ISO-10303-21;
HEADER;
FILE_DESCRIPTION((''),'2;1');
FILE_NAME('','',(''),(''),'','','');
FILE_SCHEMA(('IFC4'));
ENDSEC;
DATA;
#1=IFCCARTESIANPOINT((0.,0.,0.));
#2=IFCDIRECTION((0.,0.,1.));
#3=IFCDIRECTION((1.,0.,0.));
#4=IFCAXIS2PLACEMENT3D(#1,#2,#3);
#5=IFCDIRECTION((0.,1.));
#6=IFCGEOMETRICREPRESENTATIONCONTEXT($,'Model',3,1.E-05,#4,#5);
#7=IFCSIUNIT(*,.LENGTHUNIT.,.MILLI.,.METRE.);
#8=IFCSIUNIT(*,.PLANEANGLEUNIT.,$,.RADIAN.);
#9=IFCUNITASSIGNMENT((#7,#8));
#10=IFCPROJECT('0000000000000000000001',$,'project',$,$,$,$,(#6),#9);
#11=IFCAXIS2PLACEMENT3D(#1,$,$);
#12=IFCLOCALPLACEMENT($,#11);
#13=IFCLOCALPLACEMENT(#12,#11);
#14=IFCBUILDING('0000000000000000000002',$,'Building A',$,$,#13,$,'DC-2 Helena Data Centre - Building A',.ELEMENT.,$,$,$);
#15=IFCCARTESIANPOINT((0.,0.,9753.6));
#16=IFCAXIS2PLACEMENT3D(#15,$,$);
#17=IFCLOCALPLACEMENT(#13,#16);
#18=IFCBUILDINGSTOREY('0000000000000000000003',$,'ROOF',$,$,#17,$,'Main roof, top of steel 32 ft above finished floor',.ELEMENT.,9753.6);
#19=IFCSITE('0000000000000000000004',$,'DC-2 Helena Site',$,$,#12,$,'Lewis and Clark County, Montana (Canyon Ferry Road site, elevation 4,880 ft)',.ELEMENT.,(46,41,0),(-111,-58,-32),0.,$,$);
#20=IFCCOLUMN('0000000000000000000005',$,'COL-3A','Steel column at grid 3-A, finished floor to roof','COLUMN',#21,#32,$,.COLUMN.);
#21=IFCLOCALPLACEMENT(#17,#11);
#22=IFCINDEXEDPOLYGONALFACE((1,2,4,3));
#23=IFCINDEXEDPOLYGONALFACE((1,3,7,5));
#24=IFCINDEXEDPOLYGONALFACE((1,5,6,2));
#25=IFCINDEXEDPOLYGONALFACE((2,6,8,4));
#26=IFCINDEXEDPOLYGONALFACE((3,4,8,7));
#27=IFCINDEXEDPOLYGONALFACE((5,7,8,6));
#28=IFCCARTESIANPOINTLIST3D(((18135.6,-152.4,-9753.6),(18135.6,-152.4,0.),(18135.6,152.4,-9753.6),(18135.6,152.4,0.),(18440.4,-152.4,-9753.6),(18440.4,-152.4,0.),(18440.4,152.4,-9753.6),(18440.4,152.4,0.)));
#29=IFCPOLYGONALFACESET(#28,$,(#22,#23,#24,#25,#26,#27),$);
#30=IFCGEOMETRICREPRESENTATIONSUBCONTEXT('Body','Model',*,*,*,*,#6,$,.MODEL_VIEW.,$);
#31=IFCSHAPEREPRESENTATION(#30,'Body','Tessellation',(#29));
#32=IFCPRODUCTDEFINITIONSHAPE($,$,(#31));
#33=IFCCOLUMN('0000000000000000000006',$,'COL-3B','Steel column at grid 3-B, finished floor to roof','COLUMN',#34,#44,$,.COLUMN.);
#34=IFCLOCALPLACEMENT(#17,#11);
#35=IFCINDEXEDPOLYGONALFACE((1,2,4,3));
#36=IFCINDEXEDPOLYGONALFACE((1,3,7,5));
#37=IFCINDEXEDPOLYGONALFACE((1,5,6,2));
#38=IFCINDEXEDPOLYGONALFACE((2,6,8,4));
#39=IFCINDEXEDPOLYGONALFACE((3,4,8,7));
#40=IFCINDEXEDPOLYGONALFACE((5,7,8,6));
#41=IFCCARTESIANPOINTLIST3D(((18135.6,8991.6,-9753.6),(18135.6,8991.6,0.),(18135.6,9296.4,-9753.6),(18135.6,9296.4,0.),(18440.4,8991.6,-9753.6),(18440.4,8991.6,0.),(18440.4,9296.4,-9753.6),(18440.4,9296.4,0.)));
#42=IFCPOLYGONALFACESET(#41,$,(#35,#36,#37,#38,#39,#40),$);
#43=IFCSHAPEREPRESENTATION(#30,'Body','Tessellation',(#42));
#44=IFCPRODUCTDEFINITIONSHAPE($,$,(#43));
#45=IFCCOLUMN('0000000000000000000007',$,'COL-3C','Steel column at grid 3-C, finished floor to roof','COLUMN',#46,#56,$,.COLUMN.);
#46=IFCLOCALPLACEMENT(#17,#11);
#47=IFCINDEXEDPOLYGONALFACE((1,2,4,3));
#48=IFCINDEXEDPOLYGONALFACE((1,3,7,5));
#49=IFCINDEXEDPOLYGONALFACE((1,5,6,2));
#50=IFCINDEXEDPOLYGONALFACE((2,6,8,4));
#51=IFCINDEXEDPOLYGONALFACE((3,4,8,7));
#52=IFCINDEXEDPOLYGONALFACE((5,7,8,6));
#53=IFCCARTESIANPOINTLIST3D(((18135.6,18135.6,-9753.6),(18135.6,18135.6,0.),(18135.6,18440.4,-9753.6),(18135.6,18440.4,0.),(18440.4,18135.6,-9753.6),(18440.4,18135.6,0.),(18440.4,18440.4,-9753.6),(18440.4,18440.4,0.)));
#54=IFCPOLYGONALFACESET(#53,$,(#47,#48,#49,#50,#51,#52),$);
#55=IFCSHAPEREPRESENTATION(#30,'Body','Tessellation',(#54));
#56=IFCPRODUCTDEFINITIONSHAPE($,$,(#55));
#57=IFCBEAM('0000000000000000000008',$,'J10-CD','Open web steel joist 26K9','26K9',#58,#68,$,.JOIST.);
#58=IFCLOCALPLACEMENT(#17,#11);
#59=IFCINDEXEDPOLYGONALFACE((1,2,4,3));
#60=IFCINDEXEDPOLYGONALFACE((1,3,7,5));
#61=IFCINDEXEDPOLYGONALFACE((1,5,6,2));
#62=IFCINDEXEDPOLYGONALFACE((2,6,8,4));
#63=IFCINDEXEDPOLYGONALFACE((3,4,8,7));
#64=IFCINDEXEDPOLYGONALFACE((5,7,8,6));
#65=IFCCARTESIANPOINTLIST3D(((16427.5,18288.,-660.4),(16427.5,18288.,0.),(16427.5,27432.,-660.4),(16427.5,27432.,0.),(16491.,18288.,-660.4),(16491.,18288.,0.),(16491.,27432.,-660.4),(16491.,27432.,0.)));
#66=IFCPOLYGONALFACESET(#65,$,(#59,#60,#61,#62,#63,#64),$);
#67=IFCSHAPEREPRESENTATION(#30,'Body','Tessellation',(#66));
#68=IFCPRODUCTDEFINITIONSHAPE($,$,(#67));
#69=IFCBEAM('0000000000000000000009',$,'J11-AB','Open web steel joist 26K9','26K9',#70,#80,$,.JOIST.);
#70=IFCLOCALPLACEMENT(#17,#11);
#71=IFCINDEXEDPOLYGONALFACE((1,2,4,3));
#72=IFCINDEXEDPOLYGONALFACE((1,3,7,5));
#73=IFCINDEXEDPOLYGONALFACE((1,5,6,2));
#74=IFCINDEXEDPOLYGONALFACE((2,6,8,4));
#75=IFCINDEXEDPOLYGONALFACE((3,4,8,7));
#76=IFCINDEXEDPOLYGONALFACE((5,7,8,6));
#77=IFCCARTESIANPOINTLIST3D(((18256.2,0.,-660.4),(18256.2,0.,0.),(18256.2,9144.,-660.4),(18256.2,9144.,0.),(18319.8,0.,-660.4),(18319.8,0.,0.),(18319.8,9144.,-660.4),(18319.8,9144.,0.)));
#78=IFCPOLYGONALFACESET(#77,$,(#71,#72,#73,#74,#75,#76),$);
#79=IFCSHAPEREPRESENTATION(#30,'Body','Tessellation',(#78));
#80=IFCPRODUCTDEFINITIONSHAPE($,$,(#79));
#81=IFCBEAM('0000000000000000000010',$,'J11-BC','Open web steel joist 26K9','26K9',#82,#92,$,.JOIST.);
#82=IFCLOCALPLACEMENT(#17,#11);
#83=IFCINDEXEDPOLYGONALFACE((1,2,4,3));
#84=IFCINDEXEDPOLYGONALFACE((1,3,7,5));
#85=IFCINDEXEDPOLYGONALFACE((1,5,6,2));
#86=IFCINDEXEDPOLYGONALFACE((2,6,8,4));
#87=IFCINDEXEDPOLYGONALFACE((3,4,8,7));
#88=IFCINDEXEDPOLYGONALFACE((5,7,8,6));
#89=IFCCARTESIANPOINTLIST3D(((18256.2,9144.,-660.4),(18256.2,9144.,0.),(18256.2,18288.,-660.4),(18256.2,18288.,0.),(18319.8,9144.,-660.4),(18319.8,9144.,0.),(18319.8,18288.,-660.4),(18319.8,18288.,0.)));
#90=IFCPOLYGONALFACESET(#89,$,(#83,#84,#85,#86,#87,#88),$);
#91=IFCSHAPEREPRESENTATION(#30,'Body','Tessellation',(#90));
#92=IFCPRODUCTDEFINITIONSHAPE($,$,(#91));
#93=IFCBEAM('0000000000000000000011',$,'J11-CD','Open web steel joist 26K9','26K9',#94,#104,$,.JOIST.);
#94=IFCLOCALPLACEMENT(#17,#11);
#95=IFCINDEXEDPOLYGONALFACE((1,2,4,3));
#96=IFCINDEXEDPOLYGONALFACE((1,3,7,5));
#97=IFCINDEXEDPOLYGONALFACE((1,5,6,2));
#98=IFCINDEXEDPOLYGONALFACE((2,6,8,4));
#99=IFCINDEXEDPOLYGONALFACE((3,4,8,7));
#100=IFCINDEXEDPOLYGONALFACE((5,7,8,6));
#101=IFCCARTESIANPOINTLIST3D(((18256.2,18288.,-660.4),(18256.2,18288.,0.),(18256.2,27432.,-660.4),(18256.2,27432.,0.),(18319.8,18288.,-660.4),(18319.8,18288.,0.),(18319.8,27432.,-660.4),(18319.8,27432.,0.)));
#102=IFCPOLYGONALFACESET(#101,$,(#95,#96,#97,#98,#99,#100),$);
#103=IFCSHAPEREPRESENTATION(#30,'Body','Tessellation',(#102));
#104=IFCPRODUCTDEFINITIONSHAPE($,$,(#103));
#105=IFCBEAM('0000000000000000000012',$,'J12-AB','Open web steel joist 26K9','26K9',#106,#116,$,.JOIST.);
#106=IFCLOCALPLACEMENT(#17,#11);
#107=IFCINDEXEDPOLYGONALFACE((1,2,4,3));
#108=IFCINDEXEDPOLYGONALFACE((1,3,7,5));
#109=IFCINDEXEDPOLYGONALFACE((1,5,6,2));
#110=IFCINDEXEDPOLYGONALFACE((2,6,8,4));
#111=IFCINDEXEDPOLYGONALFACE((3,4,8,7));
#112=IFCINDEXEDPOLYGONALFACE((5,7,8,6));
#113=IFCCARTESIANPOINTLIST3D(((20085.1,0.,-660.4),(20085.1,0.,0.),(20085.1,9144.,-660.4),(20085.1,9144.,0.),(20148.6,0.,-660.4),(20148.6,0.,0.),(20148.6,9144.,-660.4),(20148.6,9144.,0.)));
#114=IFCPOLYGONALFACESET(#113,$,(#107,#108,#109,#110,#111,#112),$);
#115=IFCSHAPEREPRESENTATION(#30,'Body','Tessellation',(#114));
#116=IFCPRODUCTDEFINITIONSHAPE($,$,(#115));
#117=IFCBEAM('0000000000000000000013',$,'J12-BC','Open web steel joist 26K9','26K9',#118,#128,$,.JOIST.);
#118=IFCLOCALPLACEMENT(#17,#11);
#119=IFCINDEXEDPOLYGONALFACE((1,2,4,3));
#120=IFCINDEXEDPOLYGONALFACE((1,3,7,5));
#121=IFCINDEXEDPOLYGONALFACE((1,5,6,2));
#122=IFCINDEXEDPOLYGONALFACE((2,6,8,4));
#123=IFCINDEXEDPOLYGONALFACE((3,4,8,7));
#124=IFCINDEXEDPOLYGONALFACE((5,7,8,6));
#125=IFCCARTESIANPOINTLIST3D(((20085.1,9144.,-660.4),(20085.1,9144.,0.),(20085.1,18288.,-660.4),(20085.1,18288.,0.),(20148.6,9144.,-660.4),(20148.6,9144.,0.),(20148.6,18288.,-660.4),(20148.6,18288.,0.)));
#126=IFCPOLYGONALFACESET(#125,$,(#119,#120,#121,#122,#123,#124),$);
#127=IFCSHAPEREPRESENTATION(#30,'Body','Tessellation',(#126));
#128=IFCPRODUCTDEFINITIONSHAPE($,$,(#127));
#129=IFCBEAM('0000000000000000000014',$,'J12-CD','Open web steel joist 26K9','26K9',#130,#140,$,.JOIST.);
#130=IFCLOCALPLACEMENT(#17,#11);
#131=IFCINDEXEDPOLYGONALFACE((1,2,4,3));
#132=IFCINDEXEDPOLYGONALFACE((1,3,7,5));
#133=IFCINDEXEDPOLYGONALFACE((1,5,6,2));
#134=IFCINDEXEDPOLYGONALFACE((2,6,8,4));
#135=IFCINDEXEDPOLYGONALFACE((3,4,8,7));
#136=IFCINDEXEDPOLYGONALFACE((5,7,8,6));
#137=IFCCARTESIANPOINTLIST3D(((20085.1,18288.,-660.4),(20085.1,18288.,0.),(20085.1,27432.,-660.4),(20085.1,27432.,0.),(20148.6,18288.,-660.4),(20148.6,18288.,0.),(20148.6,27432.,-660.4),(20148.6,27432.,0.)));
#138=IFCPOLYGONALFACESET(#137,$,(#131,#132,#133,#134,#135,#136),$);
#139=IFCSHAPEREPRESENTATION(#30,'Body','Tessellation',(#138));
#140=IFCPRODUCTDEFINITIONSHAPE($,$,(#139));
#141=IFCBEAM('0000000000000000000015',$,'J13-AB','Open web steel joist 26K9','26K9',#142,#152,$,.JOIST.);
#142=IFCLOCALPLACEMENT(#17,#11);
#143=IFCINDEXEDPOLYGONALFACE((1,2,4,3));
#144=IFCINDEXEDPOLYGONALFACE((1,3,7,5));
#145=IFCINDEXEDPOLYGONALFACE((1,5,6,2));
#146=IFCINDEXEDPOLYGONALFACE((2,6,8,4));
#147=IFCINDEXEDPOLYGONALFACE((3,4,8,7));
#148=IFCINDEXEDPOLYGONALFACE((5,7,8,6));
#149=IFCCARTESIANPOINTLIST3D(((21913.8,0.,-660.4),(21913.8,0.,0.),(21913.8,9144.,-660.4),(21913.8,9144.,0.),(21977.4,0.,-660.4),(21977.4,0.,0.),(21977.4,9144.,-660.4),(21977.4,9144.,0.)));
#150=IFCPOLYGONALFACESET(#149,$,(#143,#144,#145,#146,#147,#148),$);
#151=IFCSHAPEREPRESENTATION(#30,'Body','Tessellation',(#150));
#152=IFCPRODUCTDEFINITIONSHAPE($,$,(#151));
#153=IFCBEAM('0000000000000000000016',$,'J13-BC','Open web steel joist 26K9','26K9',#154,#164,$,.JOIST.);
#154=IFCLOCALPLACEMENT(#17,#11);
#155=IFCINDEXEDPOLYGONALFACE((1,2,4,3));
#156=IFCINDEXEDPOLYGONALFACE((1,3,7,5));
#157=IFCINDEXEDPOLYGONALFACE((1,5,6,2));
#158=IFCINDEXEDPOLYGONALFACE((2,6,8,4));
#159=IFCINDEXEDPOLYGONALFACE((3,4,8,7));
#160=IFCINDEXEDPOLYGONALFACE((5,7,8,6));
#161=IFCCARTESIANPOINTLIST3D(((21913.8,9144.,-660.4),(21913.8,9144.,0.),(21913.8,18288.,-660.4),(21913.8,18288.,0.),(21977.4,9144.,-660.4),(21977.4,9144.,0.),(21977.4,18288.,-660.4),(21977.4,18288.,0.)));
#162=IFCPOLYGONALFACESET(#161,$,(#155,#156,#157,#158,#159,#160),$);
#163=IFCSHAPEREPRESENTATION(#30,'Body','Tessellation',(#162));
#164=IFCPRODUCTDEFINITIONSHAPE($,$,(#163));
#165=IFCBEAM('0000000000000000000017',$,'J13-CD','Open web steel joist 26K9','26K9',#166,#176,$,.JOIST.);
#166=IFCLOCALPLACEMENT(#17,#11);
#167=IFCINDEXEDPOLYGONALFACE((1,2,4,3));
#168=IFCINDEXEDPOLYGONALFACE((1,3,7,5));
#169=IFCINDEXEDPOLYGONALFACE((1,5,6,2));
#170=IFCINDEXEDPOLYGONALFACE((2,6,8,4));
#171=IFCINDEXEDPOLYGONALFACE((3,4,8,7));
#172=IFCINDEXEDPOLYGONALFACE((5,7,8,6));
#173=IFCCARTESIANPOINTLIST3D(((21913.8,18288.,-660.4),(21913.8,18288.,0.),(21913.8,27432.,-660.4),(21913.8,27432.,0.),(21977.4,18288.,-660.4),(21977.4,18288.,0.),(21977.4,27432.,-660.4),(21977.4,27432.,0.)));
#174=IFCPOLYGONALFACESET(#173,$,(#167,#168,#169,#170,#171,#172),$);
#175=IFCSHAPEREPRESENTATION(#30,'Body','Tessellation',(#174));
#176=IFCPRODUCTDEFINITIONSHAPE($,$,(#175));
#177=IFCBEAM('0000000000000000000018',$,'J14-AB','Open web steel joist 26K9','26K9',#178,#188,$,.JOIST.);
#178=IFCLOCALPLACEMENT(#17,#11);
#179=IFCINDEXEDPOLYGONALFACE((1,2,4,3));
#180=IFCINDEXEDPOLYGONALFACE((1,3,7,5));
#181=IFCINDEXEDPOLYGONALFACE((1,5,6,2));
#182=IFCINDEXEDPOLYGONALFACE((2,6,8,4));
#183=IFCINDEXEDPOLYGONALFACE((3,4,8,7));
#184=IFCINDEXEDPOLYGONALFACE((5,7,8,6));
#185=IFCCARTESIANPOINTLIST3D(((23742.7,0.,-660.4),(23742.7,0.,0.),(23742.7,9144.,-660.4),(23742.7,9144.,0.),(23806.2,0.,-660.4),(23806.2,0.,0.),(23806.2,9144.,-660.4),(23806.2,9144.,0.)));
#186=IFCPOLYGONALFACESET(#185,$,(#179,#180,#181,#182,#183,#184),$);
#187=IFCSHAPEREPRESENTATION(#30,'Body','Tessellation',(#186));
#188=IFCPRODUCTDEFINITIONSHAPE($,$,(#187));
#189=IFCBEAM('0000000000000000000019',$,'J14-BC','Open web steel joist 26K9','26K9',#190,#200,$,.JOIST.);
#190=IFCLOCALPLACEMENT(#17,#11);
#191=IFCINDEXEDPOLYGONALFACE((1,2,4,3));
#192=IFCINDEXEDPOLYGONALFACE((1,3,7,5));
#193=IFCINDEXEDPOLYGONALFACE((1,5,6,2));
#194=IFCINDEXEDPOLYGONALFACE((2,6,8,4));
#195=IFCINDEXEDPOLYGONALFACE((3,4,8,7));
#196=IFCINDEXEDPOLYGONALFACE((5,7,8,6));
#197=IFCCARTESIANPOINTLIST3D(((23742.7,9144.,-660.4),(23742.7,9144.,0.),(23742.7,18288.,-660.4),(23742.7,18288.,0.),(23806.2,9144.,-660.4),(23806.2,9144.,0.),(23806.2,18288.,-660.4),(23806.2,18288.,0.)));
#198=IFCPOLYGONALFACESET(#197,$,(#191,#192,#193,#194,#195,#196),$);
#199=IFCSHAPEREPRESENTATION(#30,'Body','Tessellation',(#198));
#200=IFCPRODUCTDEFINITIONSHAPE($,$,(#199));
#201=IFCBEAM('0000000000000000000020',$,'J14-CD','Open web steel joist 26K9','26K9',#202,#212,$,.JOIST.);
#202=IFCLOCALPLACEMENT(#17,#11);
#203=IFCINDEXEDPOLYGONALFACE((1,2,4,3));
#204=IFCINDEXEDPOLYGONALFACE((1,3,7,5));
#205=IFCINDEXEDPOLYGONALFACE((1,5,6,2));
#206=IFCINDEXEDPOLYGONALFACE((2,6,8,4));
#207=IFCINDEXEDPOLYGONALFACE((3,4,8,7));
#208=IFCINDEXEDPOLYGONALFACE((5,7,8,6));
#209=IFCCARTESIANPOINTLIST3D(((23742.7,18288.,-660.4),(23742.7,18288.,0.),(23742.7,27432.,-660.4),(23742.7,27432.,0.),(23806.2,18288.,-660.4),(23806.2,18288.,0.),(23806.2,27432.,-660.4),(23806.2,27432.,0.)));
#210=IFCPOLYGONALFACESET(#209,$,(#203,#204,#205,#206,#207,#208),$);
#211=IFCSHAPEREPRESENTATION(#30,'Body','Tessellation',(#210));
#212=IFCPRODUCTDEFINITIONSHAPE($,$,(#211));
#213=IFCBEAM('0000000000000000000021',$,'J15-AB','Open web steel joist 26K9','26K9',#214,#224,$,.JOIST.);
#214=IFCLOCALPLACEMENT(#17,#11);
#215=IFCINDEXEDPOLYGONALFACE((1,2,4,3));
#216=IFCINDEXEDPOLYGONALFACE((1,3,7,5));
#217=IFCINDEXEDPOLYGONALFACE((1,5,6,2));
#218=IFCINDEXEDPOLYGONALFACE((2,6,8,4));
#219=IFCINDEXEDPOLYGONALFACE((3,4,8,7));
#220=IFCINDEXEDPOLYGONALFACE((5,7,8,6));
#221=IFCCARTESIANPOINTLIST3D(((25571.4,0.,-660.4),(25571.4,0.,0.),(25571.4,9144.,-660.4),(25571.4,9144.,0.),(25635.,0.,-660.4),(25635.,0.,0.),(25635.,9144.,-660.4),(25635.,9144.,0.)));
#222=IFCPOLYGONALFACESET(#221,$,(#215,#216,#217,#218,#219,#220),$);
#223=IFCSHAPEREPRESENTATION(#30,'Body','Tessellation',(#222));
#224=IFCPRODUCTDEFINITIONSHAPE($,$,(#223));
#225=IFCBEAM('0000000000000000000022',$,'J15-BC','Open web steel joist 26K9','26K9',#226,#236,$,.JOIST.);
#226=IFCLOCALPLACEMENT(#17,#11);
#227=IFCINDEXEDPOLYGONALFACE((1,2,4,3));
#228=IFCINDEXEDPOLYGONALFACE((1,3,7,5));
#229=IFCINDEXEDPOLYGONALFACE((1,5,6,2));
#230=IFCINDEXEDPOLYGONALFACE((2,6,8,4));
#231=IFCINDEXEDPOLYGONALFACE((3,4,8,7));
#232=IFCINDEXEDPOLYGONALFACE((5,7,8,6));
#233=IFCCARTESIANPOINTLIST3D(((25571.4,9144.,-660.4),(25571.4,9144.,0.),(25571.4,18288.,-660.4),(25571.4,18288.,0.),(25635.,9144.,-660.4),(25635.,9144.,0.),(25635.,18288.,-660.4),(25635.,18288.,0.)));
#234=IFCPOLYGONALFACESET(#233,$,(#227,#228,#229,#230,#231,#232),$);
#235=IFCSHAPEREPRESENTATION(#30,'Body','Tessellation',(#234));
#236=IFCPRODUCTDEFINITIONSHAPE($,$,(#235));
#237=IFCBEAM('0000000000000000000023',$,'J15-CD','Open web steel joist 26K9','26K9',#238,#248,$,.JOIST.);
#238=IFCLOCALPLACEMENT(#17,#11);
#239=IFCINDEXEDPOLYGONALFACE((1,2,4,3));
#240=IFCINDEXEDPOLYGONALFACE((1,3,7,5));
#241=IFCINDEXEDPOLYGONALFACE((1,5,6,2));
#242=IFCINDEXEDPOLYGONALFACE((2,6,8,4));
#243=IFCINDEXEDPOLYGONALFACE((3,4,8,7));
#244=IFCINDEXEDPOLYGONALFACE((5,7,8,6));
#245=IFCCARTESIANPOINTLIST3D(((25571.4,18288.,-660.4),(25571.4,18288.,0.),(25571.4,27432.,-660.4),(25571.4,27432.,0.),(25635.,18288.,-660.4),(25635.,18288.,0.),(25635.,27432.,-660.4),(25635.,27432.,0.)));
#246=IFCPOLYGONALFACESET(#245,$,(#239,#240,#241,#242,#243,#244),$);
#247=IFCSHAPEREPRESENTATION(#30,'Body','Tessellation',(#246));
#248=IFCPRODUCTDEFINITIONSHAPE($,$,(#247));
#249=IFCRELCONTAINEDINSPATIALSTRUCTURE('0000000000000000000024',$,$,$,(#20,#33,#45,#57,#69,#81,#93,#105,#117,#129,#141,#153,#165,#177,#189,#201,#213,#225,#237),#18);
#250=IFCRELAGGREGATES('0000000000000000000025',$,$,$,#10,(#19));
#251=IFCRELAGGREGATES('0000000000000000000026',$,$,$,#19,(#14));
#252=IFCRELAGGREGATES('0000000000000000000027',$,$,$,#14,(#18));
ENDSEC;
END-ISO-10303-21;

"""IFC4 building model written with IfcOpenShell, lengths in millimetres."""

from ifc_helpers import new_model, si_unit, direction, frame, origin, origin_with_axes, origin_2d, place, context, subcontext, project, spatial, rectangle, extrude, element, save


model = new_model("IFC4")

# Units and contexts
model_context = context("Model", 3, precision=1e-05, world=origin_with_axes(), true_north=direction((0.0, 1.0)))
body_context = subcontext(model_context, "Body", "Model", "MODEL_VIEW")
ifc_project = project(units=[si_unit("LENGTHUNIT", "METRE", prefix="MILLI"), si_unit("PLANEANGLEUNIT", "RADIAN")], contexts=[model_context])

# Site, building, storey
site_placement = place(None, origin())
site = spatial("IfcSite", under=ifc_project, at=site_placement, Name="DC-2 Helena Site", LongName="Lewis and Clark County, Montana (Canyon Ferry Road site, elevation 4,880 ft)", CompositionType="ELEMENT", RefLatitude=(46, 41, 0), RefLongitude=(-111, -58, -32), RefElevation=0.0)
building_placement = place(site_placement, origin())
building = spatial("IfcBuilding", under=site, at=building_placement, Name="Building A", LongName="DC-2 Helena Data Centre - Building A", CompositionType="ELEMENT")
storey_placement = place(building_placement, frame((0.0, 0.0, 9753.6)))
storey = spatial("IfcBuildingStorey", under=building, at=storey_placement, Name="ROOF", LongName="Main roof, top of steel 32 ft above finished floor", CompositionType="ELEMENT", Elevation=9753.6)

# Columns
placement_1 = place(storey_placement, frame((18288.0, 0.0, -9753.6)))
element("IfcColumn", 1, at=placement_1, inside=storey, Name="COL-3A", Description="Steel column at grid 3-A, finished floor to roof", ObjectType="COLUMN", PredefinedType="COLUMN", context=body_context, shape_type="SweptSolid", body=[
    extrude(rectangle(XDim=304.8, YDim=304.8, at=origin_2d()), origin(), (0.0, 0.0, 1.0), 9753.6),
])
for number, where, name, description in (
    (2, (18288.0, 9144.0, -9753.6), "COL-3B", "Steel column at grid 3-B, finished floor to roof"),
    (3, (18288.0, 18288.0, -9753.6), "COL-3C", "Steel column at grid 3-C, finished floor to roof"),
):
    element("IfcColumn", number, at=place(storey_placement, frame(where)), inside=storey, Name=name, Description=description, ObjectType="COLUMN", PredefinedType="COLUMN", context=body_context, shape_type="SweptSolid", body=[
        extrude(rectangle(XDim=304.8, YDim=304.8, at=origin_2d()), origin(), (0.0, 0.0, 1.0), 9753.6),
    ])

# Beams
beam_1_placement = place(storey_placement, frame((16459.2, 18288.0, 0.0)))
element("IfcBeam", 4, at=beam_1_placement, inside=storey, Name="J10-CD", Description="Open web steel joist 26K9", ObjectType="26K9", PredefinedType="JOIST", context=body_context, shape_type="SweptSolid", body=[
    extrude(rectangle(XDim=63.5, YDim=660.4, at=origin_2d()), frame((0.0, 0.0, -330.2), z_axis=(0.0, 1.0, 0.0), x_axis=(1.0, 0.0, 0.0)), (0.0, 0.0, 1.0), 9144.0),
])
placement_2 = place(storey_placement, frame((18288.0, 0.0, 0.0)))
element("IfcBeam", 5, at=placement_2, inside=storey, Name="J11-AB", Description="Open web steel joist 26K9", ObjectType="26K9", PredefinedType="JOIST", context=body_context, shape_type="SweptSolid", body=[
    extrude(rectangle(XDim=63.5, YDim=660.4, at=origin_2d()), frame((0.0, 0.0, -330.2), z_axis=(0.0, 1.0, 0.0), x_axis=(1.0, 0.0, 0.0)), (0.0, 0.0, 1.0), 9144.0),
])
placement_3 = place(storey_placement, frame((18288.0, 9144.0, 0.0)))
element("IfcBeam", 6, at=placement_3, inside=storey, Name="J11-BC", Description="Open web steel joist 26K9", ObjectType="26K9", PredefinedType="JOIST", context=body_context, shape_type="SweptSolid", body=[
    extrude(rectangle(XDim=63.5, YDim=660.4, at=origin_2d()), frame((0.0, 0.0, -330.2), z_axis=(0.0, 1.0, 0.0), x_axis=(1.0, 0.0, 0.0)), (0.0, 0.0, 1.0), 9144.0),
])
placement_4 = place(storey_placement, frame((18288.0, 18288.0, 0.0)))
element("IfcBeam", 7, at=placement_4, inside=storey, Name="J11-CD", Description="Open web steel joist 26K9", ObjectType="26K9", PredefinedType="JOIST", context=body_context, shape_type="SweptSolid", body=[
    extrude(rectangle(XDim=63.5, YDim=660.4, at=origin_2d()), frame((0.0, 0.0, -330.2), z_axis=(0.0, 1.0, 0.0), x_axis=(1.0, 0.0, 0.0)), (0.0, 0.0, 1.0), 9144.0),
])
for number, where, name in (
    (8, (20116.8, 0.0, 0.0), "J12-AB"),
    (9, (20116.8, 9144.0, 0.0), "J12-BC"),
    (10, (20116.8, 18288.0, 0.0), "J12-CD"),
    (11, (21945.6, 0.0, 0.0), "J13-AB"),
    (12, (21945.6, 9144.0, 0.0), "J13-BC"),
    (13, (21945.6, 18288.0, 0.0), "J13-CD"),
    (14, (23774.4, 0.0, 0.0), "J14-AB"),
    (15, (23774.4, 9144.0, 0.0), "J14-BC"),
    (16, (23774.4, 18288.0, 0.0), "J14-CD"),
    (17, (25603.2, 0.0, 0.0), "J15-AB"),
    (18, (25603.2, 9144.0, 0.0), "J15-BC"),
    (19, (25603.2, 18288.0, 0.0), "J15-CD"),
):
    element("IfcBeam", number, at=place(storey_placement, frame(where)), inside=storey, Name=name, Description="Open web steel joist 26K9", ObjectType="26K9", PredefinedType="JOIST", context=body_context, shape_type="SweptSolid", body=[
        extrude(rectangle(XDim=63.5, YDim=660.4, at=origin_2d()), frame((0.0, 0.0, -330.2), z_axis=(0.0, 1.0, 0.0), x_axis=(1.0, 0.0, 0.0)), (0.0, 0.0, 1.0), 9144.0),
    ])

save(model, "model.ifc")
